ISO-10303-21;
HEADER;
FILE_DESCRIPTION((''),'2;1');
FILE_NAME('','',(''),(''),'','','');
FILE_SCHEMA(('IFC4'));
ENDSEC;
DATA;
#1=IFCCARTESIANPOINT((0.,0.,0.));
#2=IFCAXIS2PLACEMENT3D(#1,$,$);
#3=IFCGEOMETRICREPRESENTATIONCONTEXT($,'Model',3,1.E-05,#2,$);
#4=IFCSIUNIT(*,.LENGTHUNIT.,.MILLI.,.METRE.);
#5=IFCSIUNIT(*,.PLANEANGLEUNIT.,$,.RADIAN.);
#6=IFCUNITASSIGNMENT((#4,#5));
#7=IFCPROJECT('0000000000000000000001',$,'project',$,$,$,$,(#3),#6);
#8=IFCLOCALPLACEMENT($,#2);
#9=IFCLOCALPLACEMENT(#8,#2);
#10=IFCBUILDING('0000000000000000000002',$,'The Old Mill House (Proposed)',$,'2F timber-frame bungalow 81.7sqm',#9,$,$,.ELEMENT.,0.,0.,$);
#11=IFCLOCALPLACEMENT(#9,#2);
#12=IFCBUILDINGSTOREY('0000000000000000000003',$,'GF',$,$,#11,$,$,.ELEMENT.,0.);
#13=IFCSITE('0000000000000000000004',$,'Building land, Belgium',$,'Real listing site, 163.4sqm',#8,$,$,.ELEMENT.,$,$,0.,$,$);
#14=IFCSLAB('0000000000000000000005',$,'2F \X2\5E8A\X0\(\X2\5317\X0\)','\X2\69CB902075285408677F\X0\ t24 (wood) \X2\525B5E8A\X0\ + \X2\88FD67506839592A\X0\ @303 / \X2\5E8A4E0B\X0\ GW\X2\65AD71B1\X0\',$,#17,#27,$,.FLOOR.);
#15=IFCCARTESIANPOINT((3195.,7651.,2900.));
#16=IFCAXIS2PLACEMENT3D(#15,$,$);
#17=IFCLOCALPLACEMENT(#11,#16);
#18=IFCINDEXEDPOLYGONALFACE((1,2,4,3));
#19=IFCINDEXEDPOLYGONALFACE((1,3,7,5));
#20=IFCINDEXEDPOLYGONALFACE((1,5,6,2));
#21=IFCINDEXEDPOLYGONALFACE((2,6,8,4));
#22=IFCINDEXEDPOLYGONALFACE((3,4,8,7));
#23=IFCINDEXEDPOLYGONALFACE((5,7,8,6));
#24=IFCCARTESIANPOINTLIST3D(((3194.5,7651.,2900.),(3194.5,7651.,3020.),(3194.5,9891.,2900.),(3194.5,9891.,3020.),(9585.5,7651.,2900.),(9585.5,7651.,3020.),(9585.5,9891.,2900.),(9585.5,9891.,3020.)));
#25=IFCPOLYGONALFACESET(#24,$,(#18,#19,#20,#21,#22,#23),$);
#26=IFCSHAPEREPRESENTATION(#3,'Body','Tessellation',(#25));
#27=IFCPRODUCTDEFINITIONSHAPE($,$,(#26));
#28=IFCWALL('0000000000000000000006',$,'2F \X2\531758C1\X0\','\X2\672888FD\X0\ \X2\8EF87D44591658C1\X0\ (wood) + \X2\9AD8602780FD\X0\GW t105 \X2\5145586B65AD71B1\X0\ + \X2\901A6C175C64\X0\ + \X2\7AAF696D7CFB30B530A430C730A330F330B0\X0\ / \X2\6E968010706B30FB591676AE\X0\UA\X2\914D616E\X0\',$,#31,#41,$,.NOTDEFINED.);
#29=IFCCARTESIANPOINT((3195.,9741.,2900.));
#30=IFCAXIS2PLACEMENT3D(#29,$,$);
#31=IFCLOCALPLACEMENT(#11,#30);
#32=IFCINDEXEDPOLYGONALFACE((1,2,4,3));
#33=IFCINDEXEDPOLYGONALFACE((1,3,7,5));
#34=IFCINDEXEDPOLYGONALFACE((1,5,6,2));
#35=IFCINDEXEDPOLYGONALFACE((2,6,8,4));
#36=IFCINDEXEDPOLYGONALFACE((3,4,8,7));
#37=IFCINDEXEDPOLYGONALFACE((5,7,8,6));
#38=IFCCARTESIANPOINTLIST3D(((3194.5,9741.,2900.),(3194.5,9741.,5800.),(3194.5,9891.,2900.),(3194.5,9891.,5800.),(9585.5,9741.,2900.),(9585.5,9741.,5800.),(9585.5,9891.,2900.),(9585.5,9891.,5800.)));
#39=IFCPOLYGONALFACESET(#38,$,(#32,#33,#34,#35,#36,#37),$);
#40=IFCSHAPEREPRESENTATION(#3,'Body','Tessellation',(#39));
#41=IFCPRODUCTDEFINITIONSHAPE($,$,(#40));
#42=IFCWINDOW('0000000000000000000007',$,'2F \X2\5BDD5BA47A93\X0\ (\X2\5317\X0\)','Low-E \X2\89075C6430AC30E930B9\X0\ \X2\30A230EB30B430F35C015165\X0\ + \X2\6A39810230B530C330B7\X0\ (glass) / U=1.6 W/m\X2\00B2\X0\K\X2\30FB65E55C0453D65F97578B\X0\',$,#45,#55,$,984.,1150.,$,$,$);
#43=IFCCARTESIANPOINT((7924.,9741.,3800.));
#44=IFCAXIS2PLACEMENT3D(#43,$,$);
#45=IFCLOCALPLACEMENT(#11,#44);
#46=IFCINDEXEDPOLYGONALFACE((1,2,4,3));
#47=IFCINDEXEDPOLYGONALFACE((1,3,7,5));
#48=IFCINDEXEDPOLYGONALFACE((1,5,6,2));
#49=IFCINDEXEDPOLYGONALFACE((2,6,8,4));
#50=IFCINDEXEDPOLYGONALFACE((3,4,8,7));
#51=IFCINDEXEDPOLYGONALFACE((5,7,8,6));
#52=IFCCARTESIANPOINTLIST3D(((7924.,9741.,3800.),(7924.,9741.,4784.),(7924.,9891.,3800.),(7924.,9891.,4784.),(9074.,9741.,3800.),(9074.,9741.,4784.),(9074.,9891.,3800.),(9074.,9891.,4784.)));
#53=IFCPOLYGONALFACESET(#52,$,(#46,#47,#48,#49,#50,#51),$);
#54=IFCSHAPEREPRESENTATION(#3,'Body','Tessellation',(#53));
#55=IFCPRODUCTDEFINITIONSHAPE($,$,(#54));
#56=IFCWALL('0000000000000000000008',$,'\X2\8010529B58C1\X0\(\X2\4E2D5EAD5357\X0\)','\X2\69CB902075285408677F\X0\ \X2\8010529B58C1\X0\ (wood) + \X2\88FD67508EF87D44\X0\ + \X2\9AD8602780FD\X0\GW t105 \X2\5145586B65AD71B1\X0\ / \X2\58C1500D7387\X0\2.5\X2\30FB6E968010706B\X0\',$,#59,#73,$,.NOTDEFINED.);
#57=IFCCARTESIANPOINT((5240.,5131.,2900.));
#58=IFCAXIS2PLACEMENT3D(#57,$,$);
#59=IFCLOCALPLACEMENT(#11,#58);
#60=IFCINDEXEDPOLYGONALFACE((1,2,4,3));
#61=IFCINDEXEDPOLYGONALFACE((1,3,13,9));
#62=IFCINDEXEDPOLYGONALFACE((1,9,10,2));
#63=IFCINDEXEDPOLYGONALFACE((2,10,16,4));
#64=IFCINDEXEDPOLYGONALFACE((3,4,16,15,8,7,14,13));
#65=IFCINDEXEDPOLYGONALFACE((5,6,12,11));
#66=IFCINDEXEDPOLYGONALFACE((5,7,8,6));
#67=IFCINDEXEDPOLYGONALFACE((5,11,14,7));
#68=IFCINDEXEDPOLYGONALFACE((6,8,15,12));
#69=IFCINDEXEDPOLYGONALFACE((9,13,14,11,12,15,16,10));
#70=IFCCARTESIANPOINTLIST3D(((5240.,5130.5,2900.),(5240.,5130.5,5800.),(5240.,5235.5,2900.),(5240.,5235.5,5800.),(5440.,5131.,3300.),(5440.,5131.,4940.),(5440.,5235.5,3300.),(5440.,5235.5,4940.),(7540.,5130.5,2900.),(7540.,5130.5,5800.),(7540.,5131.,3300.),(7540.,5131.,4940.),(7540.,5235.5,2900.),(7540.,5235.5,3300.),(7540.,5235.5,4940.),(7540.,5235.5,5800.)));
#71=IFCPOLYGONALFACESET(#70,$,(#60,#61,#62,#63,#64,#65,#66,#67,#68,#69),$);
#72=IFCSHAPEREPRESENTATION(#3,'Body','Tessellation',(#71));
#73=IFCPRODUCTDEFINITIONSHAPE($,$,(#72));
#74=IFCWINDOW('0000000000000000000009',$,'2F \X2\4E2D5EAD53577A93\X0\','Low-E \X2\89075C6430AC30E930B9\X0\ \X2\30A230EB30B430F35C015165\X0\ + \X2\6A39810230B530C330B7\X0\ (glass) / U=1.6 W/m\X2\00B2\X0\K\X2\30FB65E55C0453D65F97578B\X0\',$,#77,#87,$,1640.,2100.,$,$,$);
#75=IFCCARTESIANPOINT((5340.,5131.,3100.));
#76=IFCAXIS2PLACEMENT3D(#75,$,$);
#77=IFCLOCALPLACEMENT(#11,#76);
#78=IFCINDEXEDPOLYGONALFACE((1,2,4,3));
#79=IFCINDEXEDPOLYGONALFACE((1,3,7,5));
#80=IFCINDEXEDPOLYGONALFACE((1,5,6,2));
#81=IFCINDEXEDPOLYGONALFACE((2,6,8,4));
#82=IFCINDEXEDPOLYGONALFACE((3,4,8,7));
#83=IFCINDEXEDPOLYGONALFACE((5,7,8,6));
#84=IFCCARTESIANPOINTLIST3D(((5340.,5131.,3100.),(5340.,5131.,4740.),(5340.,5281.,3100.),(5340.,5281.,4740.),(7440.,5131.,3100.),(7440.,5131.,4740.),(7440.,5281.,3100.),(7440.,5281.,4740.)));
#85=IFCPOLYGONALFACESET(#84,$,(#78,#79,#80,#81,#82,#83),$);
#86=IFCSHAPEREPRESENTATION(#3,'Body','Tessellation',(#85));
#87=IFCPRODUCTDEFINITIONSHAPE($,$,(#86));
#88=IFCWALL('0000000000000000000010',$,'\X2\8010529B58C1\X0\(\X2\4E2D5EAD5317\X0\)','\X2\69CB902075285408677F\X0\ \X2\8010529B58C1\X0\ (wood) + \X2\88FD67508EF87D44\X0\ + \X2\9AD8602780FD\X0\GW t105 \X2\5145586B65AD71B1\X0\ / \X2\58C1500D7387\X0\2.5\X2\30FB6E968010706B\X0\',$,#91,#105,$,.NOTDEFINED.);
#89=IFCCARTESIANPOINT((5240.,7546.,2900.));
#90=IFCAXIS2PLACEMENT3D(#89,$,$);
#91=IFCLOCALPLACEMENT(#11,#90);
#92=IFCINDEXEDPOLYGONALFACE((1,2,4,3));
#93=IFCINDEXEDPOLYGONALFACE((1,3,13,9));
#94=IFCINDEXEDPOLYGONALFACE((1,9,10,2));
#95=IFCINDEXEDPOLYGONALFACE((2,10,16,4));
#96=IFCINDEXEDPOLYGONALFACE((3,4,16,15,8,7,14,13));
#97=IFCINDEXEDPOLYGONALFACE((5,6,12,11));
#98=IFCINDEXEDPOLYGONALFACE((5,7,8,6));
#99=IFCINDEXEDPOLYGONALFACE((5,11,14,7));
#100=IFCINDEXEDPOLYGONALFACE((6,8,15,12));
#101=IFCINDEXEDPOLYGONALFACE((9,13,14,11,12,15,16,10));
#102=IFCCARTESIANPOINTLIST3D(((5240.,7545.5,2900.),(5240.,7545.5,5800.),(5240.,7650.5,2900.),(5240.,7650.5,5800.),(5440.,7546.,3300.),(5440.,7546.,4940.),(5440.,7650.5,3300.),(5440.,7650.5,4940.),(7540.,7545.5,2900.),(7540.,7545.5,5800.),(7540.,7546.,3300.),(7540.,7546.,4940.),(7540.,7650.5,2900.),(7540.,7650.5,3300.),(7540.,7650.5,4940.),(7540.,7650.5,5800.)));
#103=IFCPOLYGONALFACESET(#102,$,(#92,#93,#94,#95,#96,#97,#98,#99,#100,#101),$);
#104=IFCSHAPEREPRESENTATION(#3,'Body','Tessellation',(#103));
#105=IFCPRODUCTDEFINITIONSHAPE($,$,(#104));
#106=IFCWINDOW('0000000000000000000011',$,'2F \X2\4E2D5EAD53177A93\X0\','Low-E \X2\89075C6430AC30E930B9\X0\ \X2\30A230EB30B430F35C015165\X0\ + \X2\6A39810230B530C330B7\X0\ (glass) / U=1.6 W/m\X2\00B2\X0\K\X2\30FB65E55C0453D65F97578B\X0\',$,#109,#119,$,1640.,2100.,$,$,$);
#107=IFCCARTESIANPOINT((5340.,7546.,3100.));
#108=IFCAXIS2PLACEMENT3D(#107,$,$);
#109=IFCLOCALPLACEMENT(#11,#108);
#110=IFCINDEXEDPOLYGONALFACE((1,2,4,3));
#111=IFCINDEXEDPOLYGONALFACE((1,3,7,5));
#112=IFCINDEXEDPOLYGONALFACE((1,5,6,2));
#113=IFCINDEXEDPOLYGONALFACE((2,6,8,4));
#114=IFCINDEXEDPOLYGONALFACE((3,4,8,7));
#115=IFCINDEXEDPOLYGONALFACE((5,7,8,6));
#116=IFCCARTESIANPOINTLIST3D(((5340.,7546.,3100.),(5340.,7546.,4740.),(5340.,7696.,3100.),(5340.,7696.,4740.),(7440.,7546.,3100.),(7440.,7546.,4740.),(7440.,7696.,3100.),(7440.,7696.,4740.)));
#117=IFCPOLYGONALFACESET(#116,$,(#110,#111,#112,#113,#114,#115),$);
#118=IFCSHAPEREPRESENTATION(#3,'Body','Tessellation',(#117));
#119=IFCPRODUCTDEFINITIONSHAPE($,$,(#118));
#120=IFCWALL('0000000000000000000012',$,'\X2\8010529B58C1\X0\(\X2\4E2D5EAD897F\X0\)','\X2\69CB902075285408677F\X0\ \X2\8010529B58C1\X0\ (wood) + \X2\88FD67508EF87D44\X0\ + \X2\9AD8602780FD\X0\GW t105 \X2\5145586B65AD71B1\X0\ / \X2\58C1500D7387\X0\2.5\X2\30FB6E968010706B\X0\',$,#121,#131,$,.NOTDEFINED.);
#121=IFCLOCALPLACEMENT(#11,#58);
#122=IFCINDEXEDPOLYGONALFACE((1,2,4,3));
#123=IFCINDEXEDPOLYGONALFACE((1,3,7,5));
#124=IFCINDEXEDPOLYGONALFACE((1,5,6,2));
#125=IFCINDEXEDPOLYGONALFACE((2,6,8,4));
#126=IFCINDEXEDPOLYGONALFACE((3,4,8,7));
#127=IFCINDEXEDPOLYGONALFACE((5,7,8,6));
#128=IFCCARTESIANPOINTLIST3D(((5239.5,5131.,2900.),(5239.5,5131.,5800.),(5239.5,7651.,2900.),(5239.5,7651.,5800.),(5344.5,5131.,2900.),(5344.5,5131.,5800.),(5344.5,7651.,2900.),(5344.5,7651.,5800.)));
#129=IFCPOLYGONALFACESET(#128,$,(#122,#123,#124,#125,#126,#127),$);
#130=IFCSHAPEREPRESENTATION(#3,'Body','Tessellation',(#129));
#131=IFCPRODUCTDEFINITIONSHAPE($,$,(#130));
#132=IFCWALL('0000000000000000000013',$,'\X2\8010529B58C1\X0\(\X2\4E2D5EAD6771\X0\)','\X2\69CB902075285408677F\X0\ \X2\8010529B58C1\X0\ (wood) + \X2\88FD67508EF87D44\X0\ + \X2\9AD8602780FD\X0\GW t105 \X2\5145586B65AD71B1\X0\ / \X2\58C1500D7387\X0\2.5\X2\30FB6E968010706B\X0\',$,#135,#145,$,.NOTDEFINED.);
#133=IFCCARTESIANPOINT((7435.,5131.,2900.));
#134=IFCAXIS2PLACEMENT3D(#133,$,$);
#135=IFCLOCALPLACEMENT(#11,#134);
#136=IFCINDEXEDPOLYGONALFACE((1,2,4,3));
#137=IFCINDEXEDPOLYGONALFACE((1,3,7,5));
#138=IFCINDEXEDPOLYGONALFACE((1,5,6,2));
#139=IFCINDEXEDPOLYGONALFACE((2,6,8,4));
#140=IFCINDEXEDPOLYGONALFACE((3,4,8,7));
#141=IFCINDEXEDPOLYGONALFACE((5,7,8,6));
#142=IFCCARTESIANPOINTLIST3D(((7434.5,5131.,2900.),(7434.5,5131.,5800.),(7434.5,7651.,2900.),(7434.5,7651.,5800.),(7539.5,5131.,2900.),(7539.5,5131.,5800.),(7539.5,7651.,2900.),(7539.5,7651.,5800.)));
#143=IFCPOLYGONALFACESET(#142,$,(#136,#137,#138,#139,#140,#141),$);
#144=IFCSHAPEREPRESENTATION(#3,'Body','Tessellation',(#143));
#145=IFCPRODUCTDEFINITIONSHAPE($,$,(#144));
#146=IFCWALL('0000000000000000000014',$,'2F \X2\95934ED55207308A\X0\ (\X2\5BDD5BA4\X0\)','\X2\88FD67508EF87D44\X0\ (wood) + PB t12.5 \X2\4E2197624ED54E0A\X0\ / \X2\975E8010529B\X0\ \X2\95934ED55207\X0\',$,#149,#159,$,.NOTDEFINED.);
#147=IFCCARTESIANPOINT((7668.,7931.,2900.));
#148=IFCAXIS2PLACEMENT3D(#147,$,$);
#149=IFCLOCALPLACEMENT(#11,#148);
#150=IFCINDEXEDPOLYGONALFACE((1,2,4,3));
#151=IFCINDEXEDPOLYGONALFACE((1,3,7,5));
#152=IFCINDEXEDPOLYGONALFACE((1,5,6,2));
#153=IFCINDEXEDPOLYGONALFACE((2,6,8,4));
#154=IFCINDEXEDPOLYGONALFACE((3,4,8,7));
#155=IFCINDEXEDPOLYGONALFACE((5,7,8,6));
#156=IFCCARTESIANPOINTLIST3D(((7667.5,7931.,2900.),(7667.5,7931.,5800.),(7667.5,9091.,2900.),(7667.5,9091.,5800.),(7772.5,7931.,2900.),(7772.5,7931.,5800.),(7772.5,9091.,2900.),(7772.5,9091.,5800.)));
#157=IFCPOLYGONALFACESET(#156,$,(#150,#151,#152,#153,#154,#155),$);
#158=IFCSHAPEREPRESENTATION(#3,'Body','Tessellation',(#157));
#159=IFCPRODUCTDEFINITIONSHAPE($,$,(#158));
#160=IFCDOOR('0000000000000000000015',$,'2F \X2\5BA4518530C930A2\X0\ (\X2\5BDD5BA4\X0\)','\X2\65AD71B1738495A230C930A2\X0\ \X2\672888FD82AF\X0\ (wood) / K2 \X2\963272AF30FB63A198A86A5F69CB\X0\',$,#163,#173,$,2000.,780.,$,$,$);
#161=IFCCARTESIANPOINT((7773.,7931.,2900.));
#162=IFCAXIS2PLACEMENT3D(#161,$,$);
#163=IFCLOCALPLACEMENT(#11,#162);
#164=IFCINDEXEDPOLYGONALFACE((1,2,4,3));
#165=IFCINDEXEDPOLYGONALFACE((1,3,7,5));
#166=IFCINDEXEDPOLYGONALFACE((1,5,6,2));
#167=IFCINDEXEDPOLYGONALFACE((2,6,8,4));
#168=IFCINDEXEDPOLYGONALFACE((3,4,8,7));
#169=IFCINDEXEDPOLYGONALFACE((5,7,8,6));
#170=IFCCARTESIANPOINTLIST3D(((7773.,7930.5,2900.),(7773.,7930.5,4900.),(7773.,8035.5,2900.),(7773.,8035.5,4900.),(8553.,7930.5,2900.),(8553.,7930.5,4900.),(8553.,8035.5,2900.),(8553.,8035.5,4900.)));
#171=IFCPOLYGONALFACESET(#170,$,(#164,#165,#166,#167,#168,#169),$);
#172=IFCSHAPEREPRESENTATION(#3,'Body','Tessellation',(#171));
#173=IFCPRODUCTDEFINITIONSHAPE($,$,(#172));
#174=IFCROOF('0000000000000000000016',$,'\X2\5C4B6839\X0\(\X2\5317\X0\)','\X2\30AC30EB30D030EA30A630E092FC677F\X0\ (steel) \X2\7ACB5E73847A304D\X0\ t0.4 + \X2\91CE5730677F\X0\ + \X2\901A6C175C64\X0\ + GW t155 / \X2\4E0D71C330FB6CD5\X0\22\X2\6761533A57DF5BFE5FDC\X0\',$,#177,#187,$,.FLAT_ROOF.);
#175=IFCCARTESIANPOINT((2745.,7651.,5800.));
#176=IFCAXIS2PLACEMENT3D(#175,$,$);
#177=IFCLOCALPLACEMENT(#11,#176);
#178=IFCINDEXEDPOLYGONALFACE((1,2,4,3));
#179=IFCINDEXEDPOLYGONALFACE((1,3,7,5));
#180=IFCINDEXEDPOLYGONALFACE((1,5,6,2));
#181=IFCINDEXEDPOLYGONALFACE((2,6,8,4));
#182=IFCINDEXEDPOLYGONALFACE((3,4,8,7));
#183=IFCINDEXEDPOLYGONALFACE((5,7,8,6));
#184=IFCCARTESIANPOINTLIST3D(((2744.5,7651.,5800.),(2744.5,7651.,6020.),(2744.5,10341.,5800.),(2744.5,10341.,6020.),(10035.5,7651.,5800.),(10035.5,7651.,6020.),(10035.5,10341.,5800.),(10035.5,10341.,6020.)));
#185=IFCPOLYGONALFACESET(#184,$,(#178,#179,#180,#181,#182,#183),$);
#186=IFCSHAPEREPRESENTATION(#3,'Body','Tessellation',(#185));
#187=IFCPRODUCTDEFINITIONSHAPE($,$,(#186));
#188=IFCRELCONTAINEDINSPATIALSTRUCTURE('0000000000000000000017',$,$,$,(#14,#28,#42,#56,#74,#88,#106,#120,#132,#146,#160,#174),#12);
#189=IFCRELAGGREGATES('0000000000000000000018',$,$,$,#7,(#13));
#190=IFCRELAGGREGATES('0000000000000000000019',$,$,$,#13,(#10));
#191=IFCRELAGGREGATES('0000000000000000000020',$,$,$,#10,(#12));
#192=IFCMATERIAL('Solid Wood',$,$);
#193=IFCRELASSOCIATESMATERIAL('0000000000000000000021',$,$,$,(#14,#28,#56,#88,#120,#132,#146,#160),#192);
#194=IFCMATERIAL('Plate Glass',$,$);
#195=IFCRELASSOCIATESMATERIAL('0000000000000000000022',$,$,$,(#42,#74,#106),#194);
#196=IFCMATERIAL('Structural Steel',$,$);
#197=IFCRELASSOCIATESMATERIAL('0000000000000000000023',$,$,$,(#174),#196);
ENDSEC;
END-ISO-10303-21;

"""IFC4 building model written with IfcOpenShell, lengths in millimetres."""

from ifc_helpers import new_model, si_unit, frame, frame_2d, origin, place, context, project, spatial, rectangle, extrude, material, element, fill, save


model = new_model("IFC4")

# Units and contexts
model_context = context("Model", 3, precision=1e-05, world=origin())
ifc_project = project(units=[si_unit("LENGTHUNIT", "METRE", prefix="MILLI"), si_unit("PLANEANGLEUNIT", "RADIAN")], contexts=[model_context])

# Site, building, storey
site_placement = place(None, origin())
site = spatial("IfcSite", under=ifc_project, at=site_placement, Name="Building land, Belgium", ObjectType="Real listing site, 163.4sqm", CompositionType="ELEMENT", RefElevation=0.0)
building_placement = place(site_placement, origin())
building = spatial("IfcBuilding", under=site, at=building_placement, Name="The Old Mill House (Proposed)", ObjectType="2F timber-frame bungalow 81.7sqm", CompositionType="ELEMENT", ElevationOfRefHeight=0.0, ElevationOfTerrain=0.0)
storey_placement = place(building_placement, origin())
storey = spatial("IfcBuildingStorey", under=building, at=storey_placement, Name="GF", CompositionType="ELEMENT", Elevation=0.0)

# Slab
ifc_material_1 = material(Name="Solid Wood")
slab_placement = place(storey_placement, frame((3195.0, 7651.0, 2900.0)))
element("IfcSlab", 1, at=slab_placement, inside=storey, material=ifc_material_1, Name="2F 床(北)", Description="構造用合板 t24 (wood) 剛床 + 製材根太 @303 / 床下 GW断熱", PredefinedType="FLOOR", context=model_context, shape_type="SweptSolid", body=[
    extrude(rectangle(XDim=6391.0, YDim=2240.0, at=frame_2d((3195.0, 1120.0))), frame((3195.0, 7651.0, 2900.0)), (0.0, 0.0, 1.0), 120.0),
])

# Walls, openings, windows
wall_1_placement = place(storey_placement, frame((3195.0, 9741.0, 2900.0)))
wall_1 = element("IfcWall", 2, at=wall_1_placement, inside=storey, material=ifc_material_1, Name="2F 北壁", Description="木製 軸組外壁 (wood) + 高性能GW t105 充填断熱 + 通気層 + 窯業系サイディング / 準耐火・外皮UA配慮", PredefinedType="NOTDEFINED", context=model_context, shape_type="SweptSolid", body=[
    extrude(rectangle(XDim=6391.0, YDim=150.0, at=frame_2d((3195.0, 75.0))), frame((3195.0, 9741.0, 2900.0)), (0.0, 0.0, 1.0), 2900.0),
])
opening_1_placement = place(storey_placement, frame((7924.0, 9741.0, 3800.0)))
opening_1 = element("IfcOpeningElement", 3, at=opening_1_placement, cuts=wall_1, PredefinedType="NOTDEFINED", context=model_context, shape_type="SweptSolid", body=[
    extrude(rectangle(XDim=1150.0, YDim=150.0, at=frame_2d((575.0, 75.0))), frame((7924.0, 9741.0, 3800.0)), (0.0, 0.0, 1.0), 984.0),
])
ifc_material_2 = material(Name="Plate Glass")
window_1_placement = place(storey_placement, frame((7924.0, 9741.0, 3800.0)))
window_1 = element("IfcWindow", 4, at=window_1_placement, inside=storey, material=ifc_material_2, Name="2F 寝室窓 (北)", Description="Low-E 複層ガラス アルゴン封入 + 樹脂サッシ (glass) / U=1.6 W/m²K・日射取得型", OverallHeight=984.0, OverallWidth=1150.0, context=model_context, shape_type="SweptSolid", body=[
    extrude(rectangle(XDim=1150.0, YDim=150.0, at=frame_2d((575.0, 75.0))), frame((7924.0, 9741.0, 3800.0)), (0.0, 0.0, 1.0), 984.0),
])
fill(opening_1, window_1)
wall_2_placement = place(storey_placement, frame((5240.0, 5131.0, 2900.0)))
wall_2 = element("IfcWall", 5, at=wall_2_placement, inside=storey, material=ifc_material_1, Name="耐力壁(中庭南)", Description="構造用合板 耐力壁 (wood) + 製材軸組 + 高性能GW t105 充填断熱 / 壁倍率2.5・準耐火", PredefinedType="NOTDEFINED", context=model_context, shape_type="SweptSolid", body=[
    extrude(rectangle(XDim=2300.0, YDim=105.0, at=frame_2d((1150.0, 52.0))), frame((5240.0, 5131.0, 2900.0)), (0.0, 0.0, 1.0), 2900.0),
])
opening_2_placement = place(storey_placement, frame((5340.0, 5131.0, 3100.0)))
opening_2 = element("IfcOpeningElement", 6, at=opening_2_placement, cuts=wall_2, PredefinedType="NOTDEFINED", context=model_context, shape_type="SweptSolid", body=[
    extrude(rectangle(XDim=2100.0, YDim=150.0, at=frame_2d((1050.0, 75.0))), frame((5340.0, 5131.0, 3100.0)), (0.0, 0.0, 1.0), 1640.0),
])
window_2_placement = place(storey_placement, frame((5340.0, 5131.0, 3100.0)))
window_2 = element("IfcWindow", 7, at=window_2_placement, inside=storey, material=ifc_material_2, Name="2F 中庭南窓", Description="Low-E 複層ガラス アルゴン封入 + 樹脂サッシ (glass) / U=1.6 W/m²K・日射取得型", OverallHeight=1640.0, OverallWidth=2100.0, context=model_context, shape_type="SweptSolid", body=[
    extrude(rectangle(XDim=2100.0, YDim=150.0, at=frame_2d((1050.0, 75.0))), frame((5340.0, 5131.0, 3100.0)), (0.0, 0.0, 1.0), 1640.0),
])
fill(opening_2, window_2)
wall_3_placement = place(storey_placement, frame((5240.0, 7546.0, 2900.0)))
wall_3 = element("IfcWall", 8, at=wall_3_placement, inside=storey, material=ifc_material_1, Name="耐力壁(中庭北)", Description="構造用合板 耐力壁 (wood) + 製材軸組 + 高性能GW t105 充填断熱 / 壁倍率2.5・準耐火", PredefinedType="NOTDEFINED", context=model_context, shape_type="SweptSolid", body=[
    extrude(rectangle(XDim=2300.0, YDim=105.0, at=frame_2d((1150.0, 52.0))), frame((5240.0, 7546.0, 2900.0)), (0.0, 0.0, 1.0), 2900.0),
])
opening_3_placement = place(storey_placement, frame((5340.0, 7546.0, 3100.0)))
opening_3 = element("IfcOpeningElement", 9, at=opening_3_placement, cuts=wall_3, PredefinedType="NOTDEFINED", context=model_context, shape_type="SweptSolid", body=[
    extrude(rectangle(XDim=2100.0, YDim=150.0, at=frame_2d((1050.0, 75.0))), frame((5340.0, 7546.0, 3100.0)), (0.0, 0.0, 1.0), 1640.0),
])
window_3_placement = place(storey_placement, frame((5340.0, 7546.0, 3100.0)))
window_3 = element("IfcWindow", 10, at=window_3_placement, inside=storey, material=ifc_material_2, Name="2F 中庭北窓", Description="Low-E 複層ガラス アルゴン封入 + 樹脂サッシ (glass) / U=1.6 W/m²K・日射取得型", OverallHeight=1640.0, OverallWidth=2100.0, context=model_context, shape_type="SweptSolid", body=[
    extrude(rectangle(XDim=2100.0, YDim=150.0, at=frame_2d((1050.0, 75.0))), frame((5340.0, 7546.0, 3100.0)), (0.0, 0.0, 1.0), 1640.0),
])
fill(opening_3, window_3)

# Walls
wall_4_placement = place(storey_placement, frame((5240.0, 5131.0, 2900.0)))
element("IfcWall", 11, at=wall_4_placement, inside=storey, material=ifc_material_1, Name="耐力壁(中庭西)", Description="構造用合板 耐力壁 (wood) + 製材軸組 + 高性能GW t105 充填断熱 / 壁倍率2.5・準耐火", PredefinedType="NOTDEFINED", context=model_context, shape_type="SweptSolid", body=[
    extrude(rectangle(XDim=105.0, YDim=2520.0, at=frame_2d((52.0, 1260.0))), frame((5240.0, 5131.0, 2900.0)), (0.0, 0.0, 1.0), 2900.0),
])
wall_5_placement = place(storey_placement, frame((7435.0, 5131.0, 2900.0)))
element("IfcWall", 12, at=wall_5_placement, inside=storey, material=ifc_material_1, Name="耐力壁(中庭東)", Description="構造用合板 耐力壁 (wood) + 製材軸組 + 高性能GW t105 充填断熱 / 壁倍率2.5・準耐火", PredefinedType="NOTDEFINED", context=model_context, shape_type="SweptSolid", body=[
    extrude(rectangle(XDim=105.0, YDim=2520.0, at=frame_2d((52.0, 1260.0))), frame((7435.0, 5131.0, 2900.0)), (0.0, 0.0, 1.0), 2900.0),
])
wall_6_placement = place(storey_placement, frame((7668.0, 7931.0, 2900.0)))
element("IfcWall", 13, at=wall_6_placement, inside=storey, material=ifc_material_1, Name="2F 間仕切り (寝室)", Description="製材軸組 (wood) + PB t12.5 両面仕上 / 非耐力 間仕切", PredefinedType="NOTDEFINED", context=model_context, shape_type="SweptSolid", body=[
    extrude(rectangle(XDim=105.0, YDim=1160.0, at=frame_2d((52.0, 580.0))), frame((7668.0, 7931.0, 2900.0)), (0.0, 0.0, 1.0), 2900.0),
])

# Door
door_placement = place(storey_placement, frame((7773.0, 7931.0, 2900.0)))
element("IfcDoor", 14, at=door_placement, inside=storey, material=ifc_material_1, Name="2F 室内ドア (寝室)", Description="断熱玄関ドア 木製芯 (wood) / K2 防犯・採風機構", OverallHeight=2000.0, OverallWidth=780.0, context=model_context, shape_type="SweptSolid", body=[
    extrude(rectangle(XDim=780.0, YDim=105.0, at=frame_2d((390.0, 52.0))), frame((7773.0, 7931.0, 2900.0)), (0.0, 0.0, 1.0), 2000.0),
])

# Roof
ifc_material_3 = material(Name="Structural Steel")
for number, where, name in (
    (15, (2745.0, 7651.0, 5800.0), "屋根(北)"),
):
    element("IfcRoof", number, at=place(storey_placement, frame(where)), inside=storey, material=ifc_material_3, Name=name, Description="ガルバリウム鋼板 (steel) 立平葺き t0.4 + 野地板 + 通気層 + GW t155 / 不燃・法22条区域対応", PredefinedType="FLAT_ROOF", context=model_context, shape_type="SweptSolid", body=[
        extrude(rectangle(XDim=7291.0, YDim=2690.0, at=frame_2d((3645.0, 1345.0))), frame((2745.0, 7651.0, 5800.0)), (0.0, 0.0, 1.0), 220.0),
    ])

save(model, "model.ifc")
